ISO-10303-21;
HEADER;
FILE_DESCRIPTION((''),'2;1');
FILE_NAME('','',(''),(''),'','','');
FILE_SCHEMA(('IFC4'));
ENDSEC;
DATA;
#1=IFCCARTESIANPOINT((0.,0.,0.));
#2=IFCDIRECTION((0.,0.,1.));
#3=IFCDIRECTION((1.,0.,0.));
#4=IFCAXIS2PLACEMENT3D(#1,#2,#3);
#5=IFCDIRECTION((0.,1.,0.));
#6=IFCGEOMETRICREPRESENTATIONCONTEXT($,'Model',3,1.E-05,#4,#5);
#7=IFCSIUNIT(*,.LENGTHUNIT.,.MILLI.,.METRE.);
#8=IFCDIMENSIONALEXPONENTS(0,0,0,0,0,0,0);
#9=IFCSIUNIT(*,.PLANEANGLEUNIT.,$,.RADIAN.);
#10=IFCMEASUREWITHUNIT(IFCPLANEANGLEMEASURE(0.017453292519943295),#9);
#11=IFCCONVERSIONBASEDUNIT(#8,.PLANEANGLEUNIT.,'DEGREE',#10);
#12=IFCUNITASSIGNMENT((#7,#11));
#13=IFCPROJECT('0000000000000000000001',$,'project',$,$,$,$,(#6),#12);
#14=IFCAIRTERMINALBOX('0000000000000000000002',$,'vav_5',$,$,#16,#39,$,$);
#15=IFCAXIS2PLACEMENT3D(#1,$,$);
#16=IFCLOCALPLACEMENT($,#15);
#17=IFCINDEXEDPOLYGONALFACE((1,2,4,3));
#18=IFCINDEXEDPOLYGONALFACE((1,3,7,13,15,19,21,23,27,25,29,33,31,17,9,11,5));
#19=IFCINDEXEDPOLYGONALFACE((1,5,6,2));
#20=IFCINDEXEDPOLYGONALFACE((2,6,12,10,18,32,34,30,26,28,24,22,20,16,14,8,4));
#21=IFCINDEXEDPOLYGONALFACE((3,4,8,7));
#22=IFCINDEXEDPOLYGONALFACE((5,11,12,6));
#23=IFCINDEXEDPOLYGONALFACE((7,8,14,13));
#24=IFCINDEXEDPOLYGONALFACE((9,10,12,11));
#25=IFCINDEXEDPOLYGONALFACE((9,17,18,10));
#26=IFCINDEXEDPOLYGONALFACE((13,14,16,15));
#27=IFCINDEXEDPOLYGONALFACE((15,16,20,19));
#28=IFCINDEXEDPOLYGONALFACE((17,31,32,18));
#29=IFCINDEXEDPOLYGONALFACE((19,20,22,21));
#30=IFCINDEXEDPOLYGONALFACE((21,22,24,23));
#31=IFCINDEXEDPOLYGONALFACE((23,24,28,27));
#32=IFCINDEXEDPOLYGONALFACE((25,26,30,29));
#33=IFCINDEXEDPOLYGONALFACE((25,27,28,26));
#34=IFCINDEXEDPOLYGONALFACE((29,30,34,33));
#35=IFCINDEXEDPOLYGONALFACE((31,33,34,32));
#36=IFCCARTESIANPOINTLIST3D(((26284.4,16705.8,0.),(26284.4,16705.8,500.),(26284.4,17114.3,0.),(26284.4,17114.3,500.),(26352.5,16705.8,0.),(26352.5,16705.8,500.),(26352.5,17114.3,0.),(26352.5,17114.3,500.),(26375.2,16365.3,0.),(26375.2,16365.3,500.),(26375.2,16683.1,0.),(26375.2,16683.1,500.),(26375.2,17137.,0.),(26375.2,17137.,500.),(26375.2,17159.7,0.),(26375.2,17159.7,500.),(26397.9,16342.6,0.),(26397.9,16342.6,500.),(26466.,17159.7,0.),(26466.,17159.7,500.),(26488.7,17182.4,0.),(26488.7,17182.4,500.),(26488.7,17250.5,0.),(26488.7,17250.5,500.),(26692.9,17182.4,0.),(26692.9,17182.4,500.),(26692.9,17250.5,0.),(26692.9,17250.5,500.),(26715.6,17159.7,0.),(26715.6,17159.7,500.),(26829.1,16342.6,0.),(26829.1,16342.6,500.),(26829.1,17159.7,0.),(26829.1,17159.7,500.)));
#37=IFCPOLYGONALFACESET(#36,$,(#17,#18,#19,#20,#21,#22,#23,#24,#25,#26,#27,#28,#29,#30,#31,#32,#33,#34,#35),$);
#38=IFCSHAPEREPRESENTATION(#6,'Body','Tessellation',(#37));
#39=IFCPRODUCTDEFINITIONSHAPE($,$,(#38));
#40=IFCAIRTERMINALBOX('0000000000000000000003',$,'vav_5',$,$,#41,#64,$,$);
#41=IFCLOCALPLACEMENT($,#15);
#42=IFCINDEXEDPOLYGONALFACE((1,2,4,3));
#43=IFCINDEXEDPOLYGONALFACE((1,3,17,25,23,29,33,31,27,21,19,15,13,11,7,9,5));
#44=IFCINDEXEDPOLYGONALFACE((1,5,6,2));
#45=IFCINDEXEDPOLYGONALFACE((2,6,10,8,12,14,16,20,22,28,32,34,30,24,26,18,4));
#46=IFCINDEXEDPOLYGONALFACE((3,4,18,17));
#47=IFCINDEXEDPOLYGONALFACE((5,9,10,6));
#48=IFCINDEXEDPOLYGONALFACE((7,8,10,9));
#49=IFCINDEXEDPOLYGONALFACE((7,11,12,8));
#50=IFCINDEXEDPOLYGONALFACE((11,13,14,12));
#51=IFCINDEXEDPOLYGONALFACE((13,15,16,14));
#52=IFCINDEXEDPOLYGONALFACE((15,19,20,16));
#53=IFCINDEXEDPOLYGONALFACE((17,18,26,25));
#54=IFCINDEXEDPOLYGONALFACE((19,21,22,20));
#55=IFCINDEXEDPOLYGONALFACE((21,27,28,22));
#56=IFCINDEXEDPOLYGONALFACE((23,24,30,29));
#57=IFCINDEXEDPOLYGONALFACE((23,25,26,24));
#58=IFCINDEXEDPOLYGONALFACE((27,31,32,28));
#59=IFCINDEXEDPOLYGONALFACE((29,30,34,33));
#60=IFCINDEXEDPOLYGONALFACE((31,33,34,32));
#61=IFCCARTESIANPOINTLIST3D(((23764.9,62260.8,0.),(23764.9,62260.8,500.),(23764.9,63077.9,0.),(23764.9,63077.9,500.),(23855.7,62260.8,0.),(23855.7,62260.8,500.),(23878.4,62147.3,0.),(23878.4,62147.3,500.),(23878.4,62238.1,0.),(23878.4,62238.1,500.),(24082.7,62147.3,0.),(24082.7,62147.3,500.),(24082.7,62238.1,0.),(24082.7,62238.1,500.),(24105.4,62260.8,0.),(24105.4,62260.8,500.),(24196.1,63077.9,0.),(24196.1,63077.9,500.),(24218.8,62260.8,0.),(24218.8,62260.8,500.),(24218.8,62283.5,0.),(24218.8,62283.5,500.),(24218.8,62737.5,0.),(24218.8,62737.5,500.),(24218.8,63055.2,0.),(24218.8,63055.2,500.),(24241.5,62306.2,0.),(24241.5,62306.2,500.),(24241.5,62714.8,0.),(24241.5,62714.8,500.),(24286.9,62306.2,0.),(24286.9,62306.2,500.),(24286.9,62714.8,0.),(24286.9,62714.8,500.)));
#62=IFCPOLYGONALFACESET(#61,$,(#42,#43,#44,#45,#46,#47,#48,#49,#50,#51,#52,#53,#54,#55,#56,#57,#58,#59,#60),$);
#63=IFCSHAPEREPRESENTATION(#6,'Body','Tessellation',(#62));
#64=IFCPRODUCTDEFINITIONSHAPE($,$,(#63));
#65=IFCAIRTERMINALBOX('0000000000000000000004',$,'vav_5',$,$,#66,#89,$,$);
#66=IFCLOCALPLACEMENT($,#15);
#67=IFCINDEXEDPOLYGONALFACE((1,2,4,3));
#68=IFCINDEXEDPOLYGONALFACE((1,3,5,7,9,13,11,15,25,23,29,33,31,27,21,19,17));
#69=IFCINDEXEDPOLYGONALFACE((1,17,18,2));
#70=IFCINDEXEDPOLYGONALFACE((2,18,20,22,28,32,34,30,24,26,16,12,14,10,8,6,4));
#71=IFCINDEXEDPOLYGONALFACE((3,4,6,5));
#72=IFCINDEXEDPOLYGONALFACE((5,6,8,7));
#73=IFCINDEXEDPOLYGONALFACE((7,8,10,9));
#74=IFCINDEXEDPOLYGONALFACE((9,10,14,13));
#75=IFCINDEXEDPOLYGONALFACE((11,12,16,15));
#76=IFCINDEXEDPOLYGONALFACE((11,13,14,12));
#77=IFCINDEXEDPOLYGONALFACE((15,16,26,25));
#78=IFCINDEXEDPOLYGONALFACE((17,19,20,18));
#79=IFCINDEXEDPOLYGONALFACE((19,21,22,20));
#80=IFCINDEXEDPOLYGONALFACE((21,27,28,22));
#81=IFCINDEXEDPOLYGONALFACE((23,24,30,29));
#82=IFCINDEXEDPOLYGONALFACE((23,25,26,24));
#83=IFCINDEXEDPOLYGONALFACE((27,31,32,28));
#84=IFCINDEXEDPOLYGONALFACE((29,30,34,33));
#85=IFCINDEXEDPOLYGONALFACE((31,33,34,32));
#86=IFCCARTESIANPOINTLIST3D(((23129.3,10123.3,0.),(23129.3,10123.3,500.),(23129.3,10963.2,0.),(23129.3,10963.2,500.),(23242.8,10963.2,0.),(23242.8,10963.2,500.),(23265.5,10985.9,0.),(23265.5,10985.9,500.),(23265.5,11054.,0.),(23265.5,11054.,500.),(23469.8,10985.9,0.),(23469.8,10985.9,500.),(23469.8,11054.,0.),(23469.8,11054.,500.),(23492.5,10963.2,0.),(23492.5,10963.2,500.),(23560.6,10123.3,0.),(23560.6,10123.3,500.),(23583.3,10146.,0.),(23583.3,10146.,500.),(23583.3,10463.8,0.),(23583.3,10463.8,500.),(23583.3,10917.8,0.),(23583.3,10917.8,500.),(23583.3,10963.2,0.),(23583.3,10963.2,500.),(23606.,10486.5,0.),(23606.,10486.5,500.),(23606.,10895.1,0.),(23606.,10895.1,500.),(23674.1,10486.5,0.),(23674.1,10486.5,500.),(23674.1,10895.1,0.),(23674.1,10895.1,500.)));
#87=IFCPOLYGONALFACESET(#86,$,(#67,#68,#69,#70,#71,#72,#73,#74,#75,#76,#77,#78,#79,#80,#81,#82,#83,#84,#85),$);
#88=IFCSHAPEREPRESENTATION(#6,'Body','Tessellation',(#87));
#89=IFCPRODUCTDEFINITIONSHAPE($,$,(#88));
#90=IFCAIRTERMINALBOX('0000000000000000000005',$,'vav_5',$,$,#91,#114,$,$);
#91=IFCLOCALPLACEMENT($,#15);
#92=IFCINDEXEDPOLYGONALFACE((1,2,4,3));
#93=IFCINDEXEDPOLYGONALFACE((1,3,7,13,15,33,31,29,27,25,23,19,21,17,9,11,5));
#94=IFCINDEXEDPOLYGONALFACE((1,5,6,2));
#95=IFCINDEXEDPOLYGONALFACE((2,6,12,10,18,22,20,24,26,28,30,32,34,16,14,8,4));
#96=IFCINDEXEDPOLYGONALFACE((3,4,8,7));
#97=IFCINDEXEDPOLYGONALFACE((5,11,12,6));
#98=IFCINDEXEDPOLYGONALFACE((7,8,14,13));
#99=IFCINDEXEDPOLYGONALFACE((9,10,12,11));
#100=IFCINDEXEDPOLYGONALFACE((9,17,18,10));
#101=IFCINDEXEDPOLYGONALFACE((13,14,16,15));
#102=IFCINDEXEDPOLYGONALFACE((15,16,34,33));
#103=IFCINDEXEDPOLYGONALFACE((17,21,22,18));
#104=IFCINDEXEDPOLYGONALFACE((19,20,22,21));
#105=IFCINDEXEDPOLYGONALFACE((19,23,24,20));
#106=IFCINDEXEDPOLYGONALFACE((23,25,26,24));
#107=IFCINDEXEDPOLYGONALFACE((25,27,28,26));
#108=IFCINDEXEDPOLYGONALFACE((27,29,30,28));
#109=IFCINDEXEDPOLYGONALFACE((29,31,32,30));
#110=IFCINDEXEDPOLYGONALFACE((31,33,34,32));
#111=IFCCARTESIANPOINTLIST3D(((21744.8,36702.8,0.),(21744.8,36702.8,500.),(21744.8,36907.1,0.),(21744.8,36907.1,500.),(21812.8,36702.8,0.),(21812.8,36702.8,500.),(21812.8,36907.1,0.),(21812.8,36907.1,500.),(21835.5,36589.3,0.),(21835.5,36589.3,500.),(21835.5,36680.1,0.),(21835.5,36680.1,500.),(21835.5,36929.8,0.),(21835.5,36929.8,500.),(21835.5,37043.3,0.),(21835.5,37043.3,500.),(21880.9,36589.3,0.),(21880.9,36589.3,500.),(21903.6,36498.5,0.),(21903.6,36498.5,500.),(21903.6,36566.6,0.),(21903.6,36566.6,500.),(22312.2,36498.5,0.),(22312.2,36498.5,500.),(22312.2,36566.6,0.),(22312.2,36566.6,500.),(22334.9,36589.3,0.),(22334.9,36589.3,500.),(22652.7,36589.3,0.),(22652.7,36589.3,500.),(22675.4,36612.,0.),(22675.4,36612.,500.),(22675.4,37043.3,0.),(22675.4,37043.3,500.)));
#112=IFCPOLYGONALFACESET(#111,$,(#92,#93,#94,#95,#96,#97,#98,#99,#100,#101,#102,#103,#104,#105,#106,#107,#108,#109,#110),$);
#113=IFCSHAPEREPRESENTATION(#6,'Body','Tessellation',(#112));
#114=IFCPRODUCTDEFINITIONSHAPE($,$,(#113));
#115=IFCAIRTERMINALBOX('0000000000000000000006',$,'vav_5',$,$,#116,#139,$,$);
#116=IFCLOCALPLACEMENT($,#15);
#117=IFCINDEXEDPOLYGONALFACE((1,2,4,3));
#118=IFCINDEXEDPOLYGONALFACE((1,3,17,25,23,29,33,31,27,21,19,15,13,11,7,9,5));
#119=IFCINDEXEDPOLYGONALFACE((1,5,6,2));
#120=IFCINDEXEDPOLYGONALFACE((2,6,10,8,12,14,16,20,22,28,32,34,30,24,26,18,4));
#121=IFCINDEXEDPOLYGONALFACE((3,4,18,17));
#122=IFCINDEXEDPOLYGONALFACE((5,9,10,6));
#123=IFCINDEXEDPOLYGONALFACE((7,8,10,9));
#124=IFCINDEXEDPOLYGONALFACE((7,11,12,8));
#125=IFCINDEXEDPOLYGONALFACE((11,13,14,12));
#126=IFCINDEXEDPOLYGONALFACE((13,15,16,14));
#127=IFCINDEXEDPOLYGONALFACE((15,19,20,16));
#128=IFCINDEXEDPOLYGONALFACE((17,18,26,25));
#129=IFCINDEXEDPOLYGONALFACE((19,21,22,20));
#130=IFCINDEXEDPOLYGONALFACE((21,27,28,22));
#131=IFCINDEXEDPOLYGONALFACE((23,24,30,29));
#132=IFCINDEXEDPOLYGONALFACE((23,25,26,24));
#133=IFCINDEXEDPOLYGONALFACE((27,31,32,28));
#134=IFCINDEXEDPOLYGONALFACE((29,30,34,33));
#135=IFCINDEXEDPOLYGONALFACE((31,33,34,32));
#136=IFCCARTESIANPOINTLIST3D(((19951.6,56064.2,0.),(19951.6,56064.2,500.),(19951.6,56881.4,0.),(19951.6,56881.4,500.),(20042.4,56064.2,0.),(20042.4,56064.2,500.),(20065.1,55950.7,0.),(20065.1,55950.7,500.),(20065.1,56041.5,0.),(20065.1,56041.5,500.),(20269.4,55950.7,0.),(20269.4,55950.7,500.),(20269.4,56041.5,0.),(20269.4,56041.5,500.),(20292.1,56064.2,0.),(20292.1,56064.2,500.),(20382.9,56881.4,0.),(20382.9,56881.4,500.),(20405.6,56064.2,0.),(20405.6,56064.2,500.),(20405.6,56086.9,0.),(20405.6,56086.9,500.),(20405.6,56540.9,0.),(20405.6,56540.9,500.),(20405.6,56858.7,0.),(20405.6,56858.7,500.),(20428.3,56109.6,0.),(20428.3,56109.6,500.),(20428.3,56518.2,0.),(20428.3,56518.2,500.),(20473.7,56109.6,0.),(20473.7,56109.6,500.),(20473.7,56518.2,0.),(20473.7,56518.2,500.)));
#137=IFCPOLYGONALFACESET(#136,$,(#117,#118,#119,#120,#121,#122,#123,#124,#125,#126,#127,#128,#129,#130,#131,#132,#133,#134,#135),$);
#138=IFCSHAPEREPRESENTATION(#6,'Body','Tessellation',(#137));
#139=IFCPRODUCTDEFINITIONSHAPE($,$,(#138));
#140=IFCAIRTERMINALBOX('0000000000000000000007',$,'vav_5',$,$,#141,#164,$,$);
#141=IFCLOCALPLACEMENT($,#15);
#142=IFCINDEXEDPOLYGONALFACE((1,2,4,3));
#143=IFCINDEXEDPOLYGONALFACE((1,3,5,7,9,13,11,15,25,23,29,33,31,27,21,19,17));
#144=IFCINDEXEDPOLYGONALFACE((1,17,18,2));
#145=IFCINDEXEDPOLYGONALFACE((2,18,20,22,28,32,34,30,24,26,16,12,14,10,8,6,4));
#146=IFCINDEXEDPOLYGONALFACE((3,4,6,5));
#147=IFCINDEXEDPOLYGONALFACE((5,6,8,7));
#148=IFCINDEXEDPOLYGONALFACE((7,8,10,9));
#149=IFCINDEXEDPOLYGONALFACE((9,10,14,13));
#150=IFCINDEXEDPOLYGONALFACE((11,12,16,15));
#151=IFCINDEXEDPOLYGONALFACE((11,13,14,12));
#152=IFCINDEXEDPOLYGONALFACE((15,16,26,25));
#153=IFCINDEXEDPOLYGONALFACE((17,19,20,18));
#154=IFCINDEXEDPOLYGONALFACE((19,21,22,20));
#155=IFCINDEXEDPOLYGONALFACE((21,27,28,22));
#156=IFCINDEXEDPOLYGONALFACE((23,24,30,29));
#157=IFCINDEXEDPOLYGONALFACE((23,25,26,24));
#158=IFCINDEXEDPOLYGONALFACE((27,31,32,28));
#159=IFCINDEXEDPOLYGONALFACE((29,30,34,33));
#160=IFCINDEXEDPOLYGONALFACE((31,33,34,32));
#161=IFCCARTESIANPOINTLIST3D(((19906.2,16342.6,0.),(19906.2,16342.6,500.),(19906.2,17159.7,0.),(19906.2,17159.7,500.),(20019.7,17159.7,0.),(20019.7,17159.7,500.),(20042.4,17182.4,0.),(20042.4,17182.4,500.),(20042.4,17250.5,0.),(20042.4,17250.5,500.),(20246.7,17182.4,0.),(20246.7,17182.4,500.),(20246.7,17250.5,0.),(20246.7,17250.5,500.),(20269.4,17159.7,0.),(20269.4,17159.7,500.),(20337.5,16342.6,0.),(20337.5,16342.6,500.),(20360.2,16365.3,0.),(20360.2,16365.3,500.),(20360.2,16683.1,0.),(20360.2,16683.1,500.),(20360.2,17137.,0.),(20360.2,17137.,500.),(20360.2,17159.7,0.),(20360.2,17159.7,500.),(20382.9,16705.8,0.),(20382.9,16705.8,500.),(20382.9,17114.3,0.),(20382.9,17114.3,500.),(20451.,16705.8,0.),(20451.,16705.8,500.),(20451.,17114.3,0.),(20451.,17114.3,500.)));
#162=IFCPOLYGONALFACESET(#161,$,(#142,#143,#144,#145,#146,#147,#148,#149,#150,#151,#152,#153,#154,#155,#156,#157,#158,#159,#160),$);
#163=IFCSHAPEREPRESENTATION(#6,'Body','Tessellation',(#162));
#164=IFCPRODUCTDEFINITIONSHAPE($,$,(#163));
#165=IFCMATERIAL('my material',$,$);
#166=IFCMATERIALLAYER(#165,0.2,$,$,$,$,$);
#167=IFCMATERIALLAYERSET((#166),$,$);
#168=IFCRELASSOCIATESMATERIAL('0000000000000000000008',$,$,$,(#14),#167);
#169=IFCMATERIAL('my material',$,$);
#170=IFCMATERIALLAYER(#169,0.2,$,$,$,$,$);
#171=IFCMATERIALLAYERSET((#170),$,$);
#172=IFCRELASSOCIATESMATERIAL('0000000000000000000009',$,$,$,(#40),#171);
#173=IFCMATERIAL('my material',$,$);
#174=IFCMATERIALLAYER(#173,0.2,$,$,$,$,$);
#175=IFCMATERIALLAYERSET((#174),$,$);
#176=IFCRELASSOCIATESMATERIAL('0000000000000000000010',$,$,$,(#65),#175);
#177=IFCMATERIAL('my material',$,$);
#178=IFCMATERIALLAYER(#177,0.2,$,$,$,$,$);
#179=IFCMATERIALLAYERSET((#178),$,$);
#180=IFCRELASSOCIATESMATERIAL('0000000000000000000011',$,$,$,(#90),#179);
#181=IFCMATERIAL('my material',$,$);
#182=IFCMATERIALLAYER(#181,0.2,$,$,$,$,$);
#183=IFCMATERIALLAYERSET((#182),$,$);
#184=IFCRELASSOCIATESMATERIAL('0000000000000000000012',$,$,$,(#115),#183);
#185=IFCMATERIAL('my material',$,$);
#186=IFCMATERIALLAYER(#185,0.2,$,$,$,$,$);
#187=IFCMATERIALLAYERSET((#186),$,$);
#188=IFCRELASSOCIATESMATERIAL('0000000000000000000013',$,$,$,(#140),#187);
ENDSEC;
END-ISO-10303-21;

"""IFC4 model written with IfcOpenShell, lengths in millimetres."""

from ifc_helpers import new_model, entity, si_unit, converted_unit, direction, origin_with_axes, place, context, project, polyline, outline, extrude, material, layer, layer_set, layer_usage, element, save


model = new_model("IFC4")

# Units and contexts
model_context = context("Model", 3, precision=1e-05, world=origin_with_axes(), true_north=direction((0.0, 1.0, 0.0)))
ifc_project = project(units=[si_unit("LENGTHUNIT", "METRE", prefix="MILLI"), converted_unit("PLANEANGLEUNIT", "DEGREE", entity("IfcPlaneAngleMeasure", 0.017453292519943295), si_unit("PLANEANGLEUNIT", "RADIAN"), dimensions=[0, 0, 0, 0, 0, 0, 0])], contexts=[model_context])

# Air terminal boxes
ifc_material_1 = material(Name="my material")
ifc_layer_1 = layer(ifc_material_1, 0.2)
ifc_layer_set_1 = layer_set([ifc_layer_1])
ifc_layer_usage_1 = layer_usage(ifc_layer_set_1, "AXIS2", "POSITIVE", -0.1)
air_terminal_box_1_placement = place(None, origin_with_axes())
element("IfcAirTerminalBox", 1, at=air_terminal_box_1_placement, material=ifc_layer_usage_1, Name="vav_5", context=model_context, shape_type="SweptSolid", body=[
    extrude(outline(polyline([(26284.4, 16705.8), (26352.5, 16705.8), (26375.2, 16683.1), (26375.2, 16365.3), (26397.9, 16342.6), (26829.1, 16342.6), (26829.1, 17159.7), (26715.6, 17159.7), (26692.9, 17182.4), (26692.9, 17250.5), (26488.7, 17250.5), (26488.7, 17182.4), (26466.0, 17159.7), (26375.2, 17159.7), (26375.2, 17137.0), (26352.5, 17114.3), (26284.4, 17114.3), (26284.4, 16705.8)])), origin_with_axes(), (0.0, 0.0, 1.0), 500.0),
])
ifc_material_2 = material(Name="my material")
ifc_layer_2 = layer(ifc_material_2, 0.2)
ifc_layer_set_2 = layer_set([ifc_layer_2])
ifc_layer_usage_2 = layer_usage(ifc_layer_set_2, "AXIS2", "POSITIVE", -0.1)
air_terminal_box_2_placement = place(None, origin_with_axes())
element("IfcAirTerminalBox", 2, at=air_terminal_box_2_placement, material=ifc_layer_usage_2, Name="vav_5", context=model_context, shape_type="SweptSolid", body=[
    extrude(outline(polyline([(23764.9, 62260.8), (23855.7, 62260.8), (23878.4, 62238.1), (23878.4, 62147.3), (24082.7, 62147.3), (24082.7, 62238.1), (24105.4, 62260.8), (24218.8, 62260.8), (24218.8, 62283.5), (24241.5, 62306.2), (24286.9, 62306.2), (24286.9, 62714.8), (24241.5, 62714.8), (24218.8, 62737.5), (24218.8, 63055.2), (24196.1, 63077.9), (23764.9, 63077.9), (23764.9, 62260.8)])), origin_with_axes(), (0.0, 0.0, 1.0), 500.0),
])
ifc_material_3 = material(Name="my material")
ifc_layer_3 = layer(ifc_material_3, 0.2)
ifc_layer_set_3 = layer_set([ifc_layer_3])
ifc_layer_usage_3 = layer_usage(ifc_layer_set_3, "AXIS2", "POSITIVE", -0.1)
air_terminal_box_3_placement = place(None, origin_with_axes())
element("IfcAirTerminalBox", 3, at=air_terminal_box_3_placement, material=ifc_layer_usage_3, Name="vav_5", context=model_context, shape_type="SweptSolid", body=[
    extrude(outline(polyline([(23129.3, 10123.3), (23560.6, 10123.3), (23583.3, 10146.0), (23583.3, 10463.8), (23606.0, 10486.5), (23674.1, 10486.5), (23674.1, 10895.1), (23606.0, 10895.1), (23583.3, 10917.8), (23583.3, 10963.2), (23492.5, 10963.2), (23469.8, 10985.9), (23469.8, 11054.0), (23265.5, 11054.0), (23265.5, 10985.9), (23242.8, 10963.2), (23129.3, 10963.2), (23129.3, 10123.3)])), origin_with_axes(), (0.0, 0.0, 1.0), 500.0),
])
ifc_material_4 = material(Name="my material")
ifc_layer_4 = layer(ifc_material_4, 0.2)
ifc_layer_set_4 = layer_set([ifc_layer_4])
ifc_layer_usage_4 = layer_usage(ifc_layer_set_4, "AXIS2", "POSITIVE", -0.1)
air_terminal_box_4_placement = place(None, origin_with_axes())
element("IfcAirTerminalBox", 4, at=air_terminal_box_4_placement, material=ifc_layer_usage_4, Name="vav_5", context=model_context, shape_type="SweptSolid", body=[
    extrude(outline(polyline([(21744.8, 36702.8), (21812.8, 36702.8), (21835.5, 36680.1), (21835.5, 36589.3), (21880.9, 36589.3), (21903.6, 36566.6), (21903.6, 36498.5), (22312.2, 36498.5), (22312.2, 36566.6), (22334.9, 36589.3), (22652.7, 36589.3), (22675.4, 36612.0), (22675.4, 37043.3), (21835.5, 37043.3), (21835.5, 36929.8), (21812.8, 36907.1), (21744.8, 36907.1), (21744.8, 36702.8)])), origin_with_axes(), (0.0, 0.0, 1.0), 500.0),
])
ifc_material_5 = material(Name="my material")
ifc_layer_5 = layer(ifc_material_5, 0.2)
ifc_layer_set_5 = layer_set([ifc_layer_5])
ifc_layer_usage_5 = layer_usage(ifc_layer_set_5, "AXIS2", "POSITIVE", -0.1)
air_terminal_box_5_placement = place(None, origin_with_axes())
element("IfcAirTerminalBox", 5, at=air_terminal_box_5_placement, material=ifc_layer_usage_5, Name="vav_5", context=model_context, shape_type="SweptSolid", body=[
    extrude(outline(polyline([(19951.6, 56064.2), (20042.4, 56064.2), (20065.1, 56041.5), (20065.1, 55950.7), (20269.4, 55950.7), (20269.4, 56041.5), (20292.1, 56064.2), (20405.6, 56064.2), (20405.6, 56086.9), (20428.3, 56109.6), (20473.7, 56109.6), (20473.7, 56518.2), (20428.3, 56518.2), (20405.6, 56540.9), (20405.6, 56858.7), (20382.9, 56881.4), (19951.6, 56881.4), (19951.6, 56064.2)])), origin_with_axes(), (0.0, 0.0, 1.0), 500.0),
])
ifc_material_6 = material(Name="my material")
ifc_layer_6 = layer(ifc_material_6, 0.2)
ifc_layer_set_6 = layer_set([ifc_layer_6])
ifc_layer_usage_6 = layer_usage(ifc_layer_set_6, "AXIS2", "POSITIVE", -0.1)
air_terminal_box_6_placement = place(None, origin_with_axes())
element("IfcAirTerminalBox", 6, at=air_terminal_box_6_placement, material=ifc_layer_usage_6, Name="vav_5", context=model_context, shape_type="SweptSolid", body=[
    extrude(outline(polyline([(19906.2, 16342.6), (20337.5, 16342.6), (20360.2, 16365.3), (20360.2, 16683.1), (20382.9, 16705.8), (20451.0, 16705.8), (20451.0, 17114.3), (20382.9, 17114.3), (20360.2, 17137.0), (20360.2, 17159.7), (20269.4, 17159.7), (20246.7, 17182.4), (20246.7, 17250.5), (20042.4, 17250.5), (20042.4, 17182.4), (20019.7, 17159.7), (19906.2, 17159.7), (19906.2, 16342.6)])), origin_with_axes(), (0.0, 0.0, 1.0), 500.0),
])

save(model, "model.ifc")
